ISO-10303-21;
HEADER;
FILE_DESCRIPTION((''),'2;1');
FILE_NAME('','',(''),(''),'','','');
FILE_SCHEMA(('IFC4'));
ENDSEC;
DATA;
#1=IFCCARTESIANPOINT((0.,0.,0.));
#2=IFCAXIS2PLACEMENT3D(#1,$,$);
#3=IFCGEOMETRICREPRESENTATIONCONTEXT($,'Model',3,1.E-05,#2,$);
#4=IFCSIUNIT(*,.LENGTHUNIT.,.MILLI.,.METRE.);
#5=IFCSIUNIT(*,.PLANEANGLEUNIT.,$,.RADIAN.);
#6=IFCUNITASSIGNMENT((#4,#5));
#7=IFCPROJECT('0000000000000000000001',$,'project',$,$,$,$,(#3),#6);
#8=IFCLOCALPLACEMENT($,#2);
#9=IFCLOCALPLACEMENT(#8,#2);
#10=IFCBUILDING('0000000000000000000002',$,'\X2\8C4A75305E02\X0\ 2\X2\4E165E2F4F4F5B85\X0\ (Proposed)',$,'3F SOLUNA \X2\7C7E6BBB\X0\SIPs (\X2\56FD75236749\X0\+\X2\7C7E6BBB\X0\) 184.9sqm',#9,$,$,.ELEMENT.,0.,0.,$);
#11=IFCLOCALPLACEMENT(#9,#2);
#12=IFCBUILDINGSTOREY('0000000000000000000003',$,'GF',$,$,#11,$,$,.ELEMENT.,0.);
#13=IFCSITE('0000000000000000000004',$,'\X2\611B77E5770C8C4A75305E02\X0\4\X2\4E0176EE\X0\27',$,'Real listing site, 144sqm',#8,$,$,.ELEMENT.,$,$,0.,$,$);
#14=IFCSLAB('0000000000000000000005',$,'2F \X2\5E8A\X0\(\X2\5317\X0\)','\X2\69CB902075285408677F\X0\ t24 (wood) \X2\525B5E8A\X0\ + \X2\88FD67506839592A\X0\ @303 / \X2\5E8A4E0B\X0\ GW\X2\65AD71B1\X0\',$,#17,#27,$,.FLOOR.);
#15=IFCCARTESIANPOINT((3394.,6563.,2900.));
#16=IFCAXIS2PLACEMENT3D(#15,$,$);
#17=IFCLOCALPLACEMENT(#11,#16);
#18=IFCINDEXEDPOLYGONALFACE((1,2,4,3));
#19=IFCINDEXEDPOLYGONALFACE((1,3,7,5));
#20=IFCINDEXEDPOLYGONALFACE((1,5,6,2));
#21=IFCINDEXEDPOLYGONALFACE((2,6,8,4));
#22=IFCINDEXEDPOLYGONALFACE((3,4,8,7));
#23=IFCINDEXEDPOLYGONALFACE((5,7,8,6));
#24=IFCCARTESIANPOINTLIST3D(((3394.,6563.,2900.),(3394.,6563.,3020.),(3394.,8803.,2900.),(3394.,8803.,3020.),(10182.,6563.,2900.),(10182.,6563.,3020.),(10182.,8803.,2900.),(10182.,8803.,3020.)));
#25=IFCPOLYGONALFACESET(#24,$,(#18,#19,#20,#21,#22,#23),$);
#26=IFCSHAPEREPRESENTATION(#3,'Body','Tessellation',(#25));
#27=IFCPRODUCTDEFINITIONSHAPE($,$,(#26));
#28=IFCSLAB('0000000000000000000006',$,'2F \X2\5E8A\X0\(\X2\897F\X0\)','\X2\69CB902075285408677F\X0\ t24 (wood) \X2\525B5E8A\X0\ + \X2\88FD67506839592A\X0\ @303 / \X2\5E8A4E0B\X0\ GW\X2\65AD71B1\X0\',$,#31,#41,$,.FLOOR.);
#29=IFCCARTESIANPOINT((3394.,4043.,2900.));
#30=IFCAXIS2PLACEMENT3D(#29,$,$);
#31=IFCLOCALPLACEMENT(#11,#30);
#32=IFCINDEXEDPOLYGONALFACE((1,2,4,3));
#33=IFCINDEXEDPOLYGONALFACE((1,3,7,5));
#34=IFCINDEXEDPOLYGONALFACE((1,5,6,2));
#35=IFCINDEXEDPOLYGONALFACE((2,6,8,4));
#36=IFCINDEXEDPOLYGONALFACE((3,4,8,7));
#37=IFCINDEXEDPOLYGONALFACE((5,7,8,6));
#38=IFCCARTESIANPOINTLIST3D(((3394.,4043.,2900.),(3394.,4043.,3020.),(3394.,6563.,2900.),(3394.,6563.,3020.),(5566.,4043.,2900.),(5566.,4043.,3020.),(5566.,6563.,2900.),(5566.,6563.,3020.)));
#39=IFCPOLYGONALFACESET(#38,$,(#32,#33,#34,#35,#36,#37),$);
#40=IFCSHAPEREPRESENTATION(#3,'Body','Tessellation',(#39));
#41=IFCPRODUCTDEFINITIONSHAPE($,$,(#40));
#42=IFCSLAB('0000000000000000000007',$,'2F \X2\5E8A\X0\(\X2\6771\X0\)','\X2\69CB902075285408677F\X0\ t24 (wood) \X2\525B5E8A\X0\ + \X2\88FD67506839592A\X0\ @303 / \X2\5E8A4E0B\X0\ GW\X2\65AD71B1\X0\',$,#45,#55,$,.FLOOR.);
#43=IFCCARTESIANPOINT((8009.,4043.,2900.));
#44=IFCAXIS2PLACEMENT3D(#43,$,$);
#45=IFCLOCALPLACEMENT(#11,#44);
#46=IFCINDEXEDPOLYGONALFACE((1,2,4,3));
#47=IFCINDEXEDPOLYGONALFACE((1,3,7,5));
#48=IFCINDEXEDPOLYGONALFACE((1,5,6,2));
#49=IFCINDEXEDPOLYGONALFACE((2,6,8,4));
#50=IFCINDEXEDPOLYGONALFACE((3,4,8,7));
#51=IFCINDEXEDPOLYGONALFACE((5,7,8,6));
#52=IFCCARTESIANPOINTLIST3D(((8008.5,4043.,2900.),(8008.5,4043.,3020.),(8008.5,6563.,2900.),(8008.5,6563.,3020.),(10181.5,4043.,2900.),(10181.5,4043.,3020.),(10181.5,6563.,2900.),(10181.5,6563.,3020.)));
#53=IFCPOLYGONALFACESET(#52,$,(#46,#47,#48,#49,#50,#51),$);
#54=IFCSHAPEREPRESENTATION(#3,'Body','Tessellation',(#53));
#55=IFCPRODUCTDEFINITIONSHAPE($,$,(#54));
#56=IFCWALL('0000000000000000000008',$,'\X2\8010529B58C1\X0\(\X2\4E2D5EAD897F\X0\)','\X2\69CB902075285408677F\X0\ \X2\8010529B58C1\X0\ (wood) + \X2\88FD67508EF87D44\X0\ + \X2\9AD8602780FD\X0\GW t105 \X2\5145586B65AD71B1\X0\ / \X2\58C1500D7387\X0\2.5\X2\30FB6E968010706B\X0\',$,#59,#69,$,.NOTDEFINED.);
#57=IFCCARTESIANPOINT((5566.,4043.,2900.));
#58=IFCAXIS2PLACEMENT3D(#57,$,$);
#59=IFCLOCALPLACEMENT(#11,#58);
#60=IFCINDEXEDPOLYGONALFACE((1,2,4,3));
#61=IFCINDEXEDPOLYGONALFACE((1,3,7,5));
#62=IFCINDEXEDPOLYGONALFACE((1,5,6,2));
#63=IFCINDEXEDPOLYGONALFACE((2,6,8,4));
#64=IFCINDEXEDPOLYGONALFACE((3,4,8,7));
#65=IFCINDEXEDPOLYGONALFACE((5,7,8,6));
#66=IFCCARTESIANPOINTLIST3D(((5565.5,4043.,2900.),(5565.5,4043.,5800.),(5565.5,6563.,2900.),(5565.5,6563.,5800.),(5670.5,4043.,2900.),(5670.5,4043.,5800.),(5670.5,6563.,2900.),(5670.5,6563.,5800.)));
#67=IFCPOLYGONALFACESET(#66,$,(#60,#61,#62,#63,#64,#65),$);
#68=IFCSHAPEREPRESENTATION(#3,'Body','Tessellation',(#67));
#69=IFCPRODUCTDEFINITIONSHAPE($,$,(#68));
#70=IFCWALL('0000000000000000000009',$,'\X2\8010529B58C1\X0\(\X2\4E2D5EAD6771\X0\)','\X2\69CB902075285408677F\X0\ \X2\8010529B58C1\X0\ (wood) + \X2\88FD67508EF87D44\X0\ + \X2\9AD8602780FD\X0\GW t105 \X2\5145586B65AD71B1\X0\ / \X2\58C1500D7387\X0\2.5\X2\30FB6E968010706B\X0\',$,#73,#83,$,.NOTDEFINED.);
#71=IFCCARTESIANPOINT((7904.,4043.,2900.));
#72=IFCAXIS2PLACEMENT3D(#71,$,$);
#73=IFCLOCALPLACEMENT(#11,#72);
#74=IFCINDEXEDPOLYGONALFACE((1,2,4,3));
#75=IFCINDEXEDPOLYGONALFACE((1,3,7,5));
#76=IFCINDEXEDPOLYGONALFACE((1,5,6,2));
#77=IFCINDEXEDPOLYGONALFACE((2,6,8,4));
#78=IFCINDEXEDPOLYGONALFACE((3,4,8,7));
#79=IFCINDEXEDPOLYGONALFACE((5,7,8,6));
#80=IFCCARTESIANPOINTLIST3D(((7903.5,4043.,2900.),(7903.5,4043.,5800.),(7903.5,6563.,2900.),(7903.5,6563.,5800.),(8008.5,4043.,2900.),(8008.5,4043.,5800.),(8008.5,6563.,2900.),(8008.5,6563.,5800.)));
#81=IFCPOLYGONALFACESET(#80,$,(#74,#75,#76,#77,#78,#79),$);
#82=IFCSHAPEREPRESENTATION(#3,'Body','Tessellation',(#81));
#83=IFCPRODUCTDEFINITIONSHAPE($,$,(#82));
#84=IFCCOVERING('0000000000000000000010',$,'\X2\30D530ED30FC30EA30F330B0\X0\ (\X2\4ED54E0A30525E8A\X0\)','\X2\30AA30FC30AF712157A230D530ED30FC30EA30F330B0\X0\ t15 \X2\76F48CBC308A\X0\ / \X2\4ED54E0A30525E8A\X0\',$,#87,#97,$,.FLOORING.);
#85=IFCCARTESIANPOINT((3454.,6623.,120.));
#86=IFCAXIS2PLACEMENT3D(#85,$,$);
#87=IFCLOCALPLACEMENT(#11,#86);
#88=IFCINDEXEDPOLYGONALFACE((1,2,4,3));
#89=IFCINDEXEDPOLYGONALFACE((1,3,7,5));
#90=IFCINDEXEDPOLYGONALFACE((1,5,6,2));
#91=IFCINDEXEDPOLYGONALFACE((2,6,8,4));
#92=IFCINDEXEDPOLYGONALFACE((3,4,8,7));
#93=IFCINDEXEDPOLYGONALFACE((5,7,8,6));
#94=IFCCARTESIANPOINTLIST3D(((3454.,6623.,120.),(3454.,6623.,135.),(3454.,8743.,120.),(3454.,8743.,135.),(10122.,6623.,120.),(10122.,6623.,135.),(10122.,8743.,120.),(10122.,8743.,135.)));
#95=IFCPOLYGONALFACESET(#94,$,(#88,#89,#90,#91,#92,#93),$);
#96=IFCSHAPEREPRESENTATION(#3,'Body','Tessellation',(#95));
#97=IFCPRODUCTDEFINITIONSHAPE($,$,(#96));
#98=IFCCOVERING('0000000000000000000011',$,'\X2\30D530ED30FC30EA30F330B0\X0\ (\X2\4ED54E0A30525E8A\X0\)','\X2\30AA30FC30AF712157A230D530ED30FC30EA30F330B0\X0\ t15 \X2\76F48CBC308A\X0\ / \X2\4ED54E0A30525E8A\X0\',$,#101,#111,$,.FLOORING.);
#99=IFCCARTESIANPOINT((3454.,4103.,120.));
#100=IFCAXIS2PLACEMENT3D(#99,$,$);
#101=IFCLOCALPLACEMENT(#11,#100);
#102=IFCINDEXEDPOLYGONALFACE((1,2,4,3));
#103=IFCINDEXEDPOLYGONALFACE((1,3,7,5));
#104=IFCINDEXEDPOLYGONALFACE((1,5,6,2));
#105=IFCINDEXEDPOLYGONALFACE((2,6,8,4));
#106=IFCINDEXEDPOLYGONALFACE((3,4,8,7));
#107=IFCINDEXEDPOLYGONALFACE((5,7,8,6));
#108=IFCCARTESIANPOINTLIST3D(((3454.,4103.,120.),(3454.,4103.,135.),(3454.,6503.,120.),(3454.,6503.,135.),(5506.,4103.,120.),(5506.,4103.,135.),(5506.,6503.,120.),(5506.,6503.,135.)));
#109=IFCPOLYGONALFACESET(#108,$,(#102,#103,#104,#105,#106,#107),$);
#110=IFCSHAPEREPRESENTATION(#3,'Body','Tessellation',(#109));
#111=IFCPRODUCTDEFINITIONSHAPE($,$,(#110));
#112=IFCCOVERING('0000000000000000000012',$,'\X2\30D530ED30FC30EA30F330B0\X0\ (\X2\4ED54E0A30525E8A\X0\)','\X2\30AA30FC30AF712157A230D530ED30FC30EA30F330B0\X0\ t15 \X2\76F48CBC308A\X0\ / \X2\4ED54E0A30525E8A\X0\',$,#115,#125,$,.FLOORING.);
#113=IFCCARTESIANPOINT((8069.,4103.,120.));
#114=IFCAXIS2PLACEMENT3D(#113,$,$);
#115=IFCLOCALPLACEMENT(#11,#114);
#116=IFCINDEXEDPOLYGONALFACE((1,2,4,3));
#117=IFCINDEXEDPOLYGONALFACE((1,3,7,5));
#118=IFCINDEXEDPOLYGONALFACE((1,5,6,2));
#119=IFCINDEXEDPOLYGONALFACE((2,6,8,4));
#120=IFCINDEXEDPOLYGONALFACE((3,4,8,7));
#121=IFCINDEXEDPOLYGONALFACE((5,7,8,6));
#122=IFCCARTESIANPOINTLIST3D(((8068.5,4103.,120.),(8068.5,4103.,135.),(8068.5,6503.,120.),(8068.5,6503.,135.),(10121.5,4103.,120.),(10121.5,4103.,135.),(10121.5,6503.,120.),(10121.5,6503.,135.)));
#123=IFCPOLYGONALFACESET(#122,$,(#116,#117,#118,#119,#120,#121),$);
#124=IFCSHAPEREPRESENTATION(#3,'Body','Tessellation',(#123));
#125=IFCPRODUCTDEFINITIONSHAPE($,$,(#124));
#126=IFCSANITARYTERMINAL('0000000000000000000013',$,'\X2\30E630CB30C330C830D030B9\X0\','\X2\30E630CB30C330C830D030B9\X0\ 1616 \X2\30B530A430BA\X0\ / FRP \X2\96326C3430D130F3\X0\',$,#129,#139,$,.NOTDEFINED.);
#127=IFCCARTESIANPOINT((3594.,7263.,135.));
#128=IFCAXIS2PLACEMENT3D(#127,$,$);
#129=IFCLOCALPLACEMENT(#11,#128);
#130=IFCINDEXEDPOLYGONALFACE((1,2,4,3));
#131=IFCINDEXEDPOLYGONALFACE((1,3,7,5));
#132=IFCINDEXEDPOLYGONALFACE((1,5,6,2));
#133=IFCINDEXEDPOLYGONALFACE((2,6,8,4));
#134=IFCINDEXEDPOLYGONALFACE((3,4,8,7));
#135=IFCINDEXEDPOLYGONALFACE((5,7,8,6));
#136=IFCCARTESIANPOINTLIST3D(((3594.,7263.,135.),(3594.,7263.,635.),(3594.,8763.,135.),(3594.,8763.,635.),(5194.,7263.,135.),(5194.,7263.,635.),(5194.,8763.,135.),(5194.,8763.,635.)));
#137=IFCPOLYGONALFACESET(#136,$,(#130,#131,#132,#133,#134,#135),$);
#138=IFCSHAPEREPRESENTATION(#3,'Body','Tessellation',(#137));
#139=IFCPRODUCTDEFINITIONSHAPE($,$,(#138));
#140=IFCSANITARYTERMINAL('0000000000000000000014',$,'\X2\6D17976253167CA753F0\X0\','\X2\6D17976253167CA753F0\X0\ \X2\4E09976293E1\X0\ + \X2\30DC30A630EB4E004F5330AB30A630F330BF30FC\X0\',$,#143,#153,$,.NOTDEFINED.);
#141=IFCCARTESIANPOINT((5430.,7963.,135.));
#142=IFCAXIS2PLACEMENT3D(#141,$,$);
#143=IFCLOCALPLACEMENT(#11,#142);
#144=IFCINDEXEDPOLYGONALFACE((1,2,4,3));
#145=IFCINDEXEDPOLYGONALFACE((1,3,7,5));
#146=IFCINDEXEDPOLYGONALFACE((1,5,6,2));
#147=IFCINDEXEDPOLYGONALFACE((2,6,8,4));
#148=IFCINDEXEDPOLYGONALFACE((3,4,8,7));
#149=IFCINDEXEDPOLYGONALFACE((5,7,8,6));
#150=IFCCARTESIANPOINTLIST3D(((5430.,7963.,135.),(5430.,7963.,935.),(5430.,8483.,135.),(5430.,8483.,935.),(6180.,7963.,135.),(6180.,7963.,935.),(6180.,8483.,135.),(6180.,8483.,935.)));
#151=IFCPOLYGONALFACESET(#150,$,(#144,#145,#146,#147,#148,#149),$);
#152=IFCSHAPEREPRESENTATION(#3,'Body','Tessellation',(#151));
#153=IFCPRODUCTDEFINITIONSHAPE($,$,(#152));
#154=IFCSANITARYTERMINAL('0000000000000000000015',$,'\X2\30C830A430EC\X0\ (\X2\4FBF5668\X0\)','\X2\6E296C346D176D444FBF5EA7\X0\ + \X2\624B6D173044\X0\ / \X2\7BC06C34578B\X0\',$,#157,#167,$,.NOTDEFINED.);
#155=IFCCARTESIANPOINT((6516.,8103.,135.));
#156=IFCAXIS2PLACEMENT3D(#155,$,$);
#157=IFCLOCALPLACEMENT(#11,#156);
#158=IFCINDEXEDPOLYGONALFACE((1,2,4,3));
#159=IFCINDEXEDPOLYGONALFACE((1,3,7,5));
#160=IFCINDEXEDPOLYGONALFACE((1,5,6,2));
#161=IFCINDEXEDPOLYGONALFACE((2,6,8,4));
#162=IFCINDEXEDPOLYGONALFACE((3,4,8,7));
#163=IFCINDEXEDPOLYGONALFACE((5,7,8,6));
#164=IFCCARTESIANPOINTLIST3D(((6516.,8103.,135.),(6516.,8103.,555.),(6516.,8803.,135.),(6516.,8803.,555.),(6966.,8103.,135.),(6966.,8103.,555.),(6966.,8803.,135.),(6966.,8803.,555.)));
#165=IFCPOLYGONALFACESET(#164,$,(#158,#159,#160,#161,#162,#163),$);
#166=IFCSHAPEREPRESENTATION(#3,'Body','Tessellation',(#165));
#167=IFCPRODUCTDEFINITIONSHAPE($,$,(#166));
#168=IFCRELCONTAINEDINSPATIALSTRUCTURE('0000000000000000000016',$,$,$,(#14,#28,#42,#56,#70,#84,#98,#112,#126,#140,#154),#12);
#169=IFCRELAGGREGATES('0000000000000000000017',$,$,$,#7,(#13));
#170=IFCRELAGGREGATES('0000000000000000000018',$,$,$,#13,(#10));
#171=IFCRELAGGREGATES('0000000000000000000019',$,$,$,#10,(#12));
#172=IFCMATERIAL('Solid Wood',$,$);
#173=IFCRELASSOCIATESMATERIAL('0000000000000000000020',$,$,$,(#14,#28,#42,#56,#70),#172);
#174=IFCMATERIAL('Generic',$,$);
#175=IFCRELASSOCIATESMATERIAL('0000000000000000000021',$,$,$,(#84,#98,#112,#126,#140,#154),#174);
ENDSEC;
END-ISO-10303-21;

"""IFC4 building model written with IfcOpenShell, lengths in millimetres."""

from ifc_helpers import new_model, si_unit, frame, frame_2d, origin, place, context, project, spatial, rectangle, extrude, material, element, save


model = new_model("IFC4")

# Units and contexts
model_context = context("Model", 3, precision=1e-05, world=origin())
ifc_project = project(units=[si_unit("LENGTHUNIT", "METRE", prefix="MILLI"), si_unit("PLANEANGLEUNIT", "RADIAN")], contexts=[model_context])

# Site, building, storey
site_placement = place(None, origin())
site = spatial("IfcSite", under=ifc_project, at=site_placement, Name="愛知県豊田市4丁目27", ObjectType="Real listing site, 144sqm", CompositionType="ELEMENT", RefElevation=0.0)
building_placement = place(site_placement, origin())
building = spatial("IfcBuilding", under=site, at=building_placement, Name="豊田市 2世帯住宅 (Proposed)", ObjectType="3F SOLUNA 籾殻SIPs (国産杉+籾殻) 184.9sqm", CompositionType="ELEMENT", ElevationOfRefHeight=0.0, ElevationOfTerrain=0.0)
storey_placement = place(building_placement, origin())
storey = spatial("IfcBuildingStorey", under=building, at=storey_placement, Name="GF", CompositionType="ELEMENT", Elevation=0.0)

# Slabs
ifc_material_1 = material(Name="Solid Wood")
slab_1_placement = place(storey_placement, frame((3394.0, 6563.0, 2900.0)))
element("IfcSlab", 1, at=slab_1_placement, inside=storey, material=ifc_material_1, Name="2F 床(北)", Description="構造用合板 t24 (wood) 剛床 + 製材根太 @303 / 床下 GW断熱", PredefinedType="FLOOR", context=model_context, shape_type="SweptSolid", body=[
    extrude(rectangle(XDim=6788.0, YDim=2240.0, at=frame_2d((3394.0, 1120.0))), frame((3394.0, 6563.0, 2900.0)), (0.0, 0.0, 1.0), 120.0),
])
slab_2_placement = place(storey_placement, frame((3394.0, 4043.0, 2900.0)))
element("IfcSlab", 2, at=slab_2_placement, inside=storey, material=ifc_material_1, Name="2F 床(西)", Description="構造用合板 t24 (wood) 剛床 + 製材根太 @303 / 床下 GW断熱", PredefinedType="FLOOR", context=model_context, shape_type="SweptSolid", body=[
    extrude(rectangle(XDim=2172.0, YDim=2520.0, at=frame_2d((1086.0, 1260.0))), frame((3394.0, 4043.0, 2900.0)), (0.0, 0.0, 1.0), 120.0),
])
slab_3_placement = place(storey_placement, frame((8009.0, 4043.0, 2900.0)))
element("IfcSlab", 3, at=slab_3_placement, inside=storey, material=ifc_material_1, Name="2F 床(東)", Description="構造用合板 t24 (wood) 剛床 + 製材根太 @303 / 床下 GW断熱", PredefinedType="FLOOR", context=model_context, shape_type="SweptSolid", body=[
    extrude(rectangle(XDim=2173.0, YDim=2520.0, at=frame_2d((1086.0, 1260.0))), frame((8009.0, 4043.0, 2900.0)), (0.0, 0.0, 1.0), 120.0),
])

# Walls
wall_1_placement = place(storey_placement, frame((5566.0, 4043.0, 2900.0)))
element("IfcWall", 4, at=wall_1_placement, inside=storey, material=ifc_material_1, Name="耐力壁(中庭西)", Description="構造用合板 耐力壁 (wood) + 製材軸組 + 高性能GW t105 充填断熱 / 壁倍率2.5・準耐火", PredefinedType="NOTDEFINED", context=model_context, shape_type="SweptSolid", body=[
    extrude(rectangle(XDim=105.0, YDim=2520.0, at=frame_2d((52.0, 1260.0))), frame((5566.0, 4043.0, 2900.0)), (0.0, 0.0, 1.0), 2900.0),
])
wall_2_placement = place(storey_placement, frame((7904.0, 4043.0, 2900.0)))
element("IfcWall", 5, at=wall_2_placement, inside=storey, material=ifc_material_1, Name="耐力壁(中庭東)", Description="構造用合板 耐力壁 (wood) + 製材軸組 + 高性能GW t105 充填断熱 / 壁倍率2.5・準耐火", PredefinedType="NOTDEFINED", context=model_context, shape_type="SweptSolid", body=[
    extrude(rectangle(XDim=105.0, YDim=2520.0, at=frame_2d((52.0, 1260.0))), frame((7904.0, 4043.0, 2900.0)), (0.0, 0.0, 1.0), 2900.0),
])

# Coverings
ifc_material_2 = material(Name="Generic")
covering_1_placement = place(storey_placement, frame((3454.0, 6623.0, 120.0)))
element("IfcCovering", 6, at=covering_1_placement, inside=storey, material=ifc_material_2, Name="フローリング (仕上げ床)", Description="オーク無垢フローリング t15 直貼り / 仕上げ床", PredefinedType="FLOORING", context=model_context, shape_type="SweptSolid", body=[
    extrude(rectangle(XDim=6668.0, YDim=2120.0, at=frame_2d((3334.0, 1060.0))), frame((3454.0, 6623.0, 120.0)), (0.0, 0.0, 1.0), 15.0),
])
covering_2_placement = place(storey_placement, frame((3454.0, 4103.0, 120.0)))
element("IfcCovering", 7, at=covering_2_placement, inside=storey, material=ifc_material_2, Name="フローリング (仕上げ床)", Description="オーク無垢フローリング t15 直貼り / 仕上げ床", PredefinedType="FLOORING", context=model_context, shape_type="SweptSolid", body=[
    extrude(rectangle(XDim=2052.0, YDim=2400.0, at=frame_2d((1026.0, 1200.0))), frame((3454.0, 4103.0, 120.0)), (0.0, 0.0, 1.0), 15.0),
])
covering_3_placement = place(storey_placement, frame((8069.0, 4103.0, 120.0)))
element("IfcCovering", 8, at=covering_3_placement, inside=storey, material=ifc_material_2, Name="フローリング (仕上げ床)", Description="オーク無垢フローリング t15 直貼り / 仕上げ床", PredefinedType="FLOORING", context=model_context, shape_type="SweptSolid", body=[
    extrude(rectangle(XDim=2053.0, YDim=2400.0, at=frame_2d((1026.0, 1200.0))), frame((8069.0, 4103.0, 120.0)), (0.0, 0.0, 1.0), 15.0),
])

# Sanitary terminals
sanitary_terminal_1_placement = place(storey_placement, frame((3594.0, 7263.0, 135.0)))
element("IfcSanitaryTerminal", 9, at=sanitary_terminal_1_placement, inside=storey, material=ifc_material_2, Name="ユニットバス", Description="ユニットバス 1616 サイズ / FRP 防水パン", PredefinedType="NOTDEFINED", context=model_context, shape_type="SweptSolid", body=[
    extrude(rectangle(XDim=1600.0, YDim=1500.0, at=frame_2d((800.0, 750.0))), frame((3594.0, 7263.0, 135.0)), (0.0, 0.0, 1.0), 500.0),
])
sanitary_terminal_2_placement = place(storey_placement, frame((5430.0, 7963.0, 135.0)))
element("IfcSanitaryTerminal", 10, at=sanitary_terminal_2_placement, inside=storey, material=ifc_material_2, Name="洗面化粧台", Description="洗面化粧台 三面鏡 + ボウル一体カウンター", PredefinedType="NOTDEFINED", context=model_context, shape_type="SweptSolid", body=[
    extrude(rectangle(XDim=750.0, YDim=520.0, at=frame_2d((375.0, 260.0))), frame((5430.0, 7963.0, 135.0)), (0.0, 0.0, 1.0), 800.0),
])
sanitary_terminal_3_placement = place(storey_placement, frame((6516.0, 8103.0, 135.0)))
element("IfcSanitaryTerminal", 11, at=sanitary_terminal_3_placement, inside=storey, material=ifc_material_2, Name="トイレ (便器)", Description="温水洗浄便座 + 手洗い / 節水型", PredefinedType="NOTDEFINED", context=model_context, shape_type="SweptSolid", body=[
    extrude(rectangle(XDim=450.0, YDim=700.0, at=frame_2d((225.0, 350.0))), frame((6516.0, 8103.0, 135.0)), (0.0, 0.0, 1.0), 420.0),
])

save(model, "model.ifc")
